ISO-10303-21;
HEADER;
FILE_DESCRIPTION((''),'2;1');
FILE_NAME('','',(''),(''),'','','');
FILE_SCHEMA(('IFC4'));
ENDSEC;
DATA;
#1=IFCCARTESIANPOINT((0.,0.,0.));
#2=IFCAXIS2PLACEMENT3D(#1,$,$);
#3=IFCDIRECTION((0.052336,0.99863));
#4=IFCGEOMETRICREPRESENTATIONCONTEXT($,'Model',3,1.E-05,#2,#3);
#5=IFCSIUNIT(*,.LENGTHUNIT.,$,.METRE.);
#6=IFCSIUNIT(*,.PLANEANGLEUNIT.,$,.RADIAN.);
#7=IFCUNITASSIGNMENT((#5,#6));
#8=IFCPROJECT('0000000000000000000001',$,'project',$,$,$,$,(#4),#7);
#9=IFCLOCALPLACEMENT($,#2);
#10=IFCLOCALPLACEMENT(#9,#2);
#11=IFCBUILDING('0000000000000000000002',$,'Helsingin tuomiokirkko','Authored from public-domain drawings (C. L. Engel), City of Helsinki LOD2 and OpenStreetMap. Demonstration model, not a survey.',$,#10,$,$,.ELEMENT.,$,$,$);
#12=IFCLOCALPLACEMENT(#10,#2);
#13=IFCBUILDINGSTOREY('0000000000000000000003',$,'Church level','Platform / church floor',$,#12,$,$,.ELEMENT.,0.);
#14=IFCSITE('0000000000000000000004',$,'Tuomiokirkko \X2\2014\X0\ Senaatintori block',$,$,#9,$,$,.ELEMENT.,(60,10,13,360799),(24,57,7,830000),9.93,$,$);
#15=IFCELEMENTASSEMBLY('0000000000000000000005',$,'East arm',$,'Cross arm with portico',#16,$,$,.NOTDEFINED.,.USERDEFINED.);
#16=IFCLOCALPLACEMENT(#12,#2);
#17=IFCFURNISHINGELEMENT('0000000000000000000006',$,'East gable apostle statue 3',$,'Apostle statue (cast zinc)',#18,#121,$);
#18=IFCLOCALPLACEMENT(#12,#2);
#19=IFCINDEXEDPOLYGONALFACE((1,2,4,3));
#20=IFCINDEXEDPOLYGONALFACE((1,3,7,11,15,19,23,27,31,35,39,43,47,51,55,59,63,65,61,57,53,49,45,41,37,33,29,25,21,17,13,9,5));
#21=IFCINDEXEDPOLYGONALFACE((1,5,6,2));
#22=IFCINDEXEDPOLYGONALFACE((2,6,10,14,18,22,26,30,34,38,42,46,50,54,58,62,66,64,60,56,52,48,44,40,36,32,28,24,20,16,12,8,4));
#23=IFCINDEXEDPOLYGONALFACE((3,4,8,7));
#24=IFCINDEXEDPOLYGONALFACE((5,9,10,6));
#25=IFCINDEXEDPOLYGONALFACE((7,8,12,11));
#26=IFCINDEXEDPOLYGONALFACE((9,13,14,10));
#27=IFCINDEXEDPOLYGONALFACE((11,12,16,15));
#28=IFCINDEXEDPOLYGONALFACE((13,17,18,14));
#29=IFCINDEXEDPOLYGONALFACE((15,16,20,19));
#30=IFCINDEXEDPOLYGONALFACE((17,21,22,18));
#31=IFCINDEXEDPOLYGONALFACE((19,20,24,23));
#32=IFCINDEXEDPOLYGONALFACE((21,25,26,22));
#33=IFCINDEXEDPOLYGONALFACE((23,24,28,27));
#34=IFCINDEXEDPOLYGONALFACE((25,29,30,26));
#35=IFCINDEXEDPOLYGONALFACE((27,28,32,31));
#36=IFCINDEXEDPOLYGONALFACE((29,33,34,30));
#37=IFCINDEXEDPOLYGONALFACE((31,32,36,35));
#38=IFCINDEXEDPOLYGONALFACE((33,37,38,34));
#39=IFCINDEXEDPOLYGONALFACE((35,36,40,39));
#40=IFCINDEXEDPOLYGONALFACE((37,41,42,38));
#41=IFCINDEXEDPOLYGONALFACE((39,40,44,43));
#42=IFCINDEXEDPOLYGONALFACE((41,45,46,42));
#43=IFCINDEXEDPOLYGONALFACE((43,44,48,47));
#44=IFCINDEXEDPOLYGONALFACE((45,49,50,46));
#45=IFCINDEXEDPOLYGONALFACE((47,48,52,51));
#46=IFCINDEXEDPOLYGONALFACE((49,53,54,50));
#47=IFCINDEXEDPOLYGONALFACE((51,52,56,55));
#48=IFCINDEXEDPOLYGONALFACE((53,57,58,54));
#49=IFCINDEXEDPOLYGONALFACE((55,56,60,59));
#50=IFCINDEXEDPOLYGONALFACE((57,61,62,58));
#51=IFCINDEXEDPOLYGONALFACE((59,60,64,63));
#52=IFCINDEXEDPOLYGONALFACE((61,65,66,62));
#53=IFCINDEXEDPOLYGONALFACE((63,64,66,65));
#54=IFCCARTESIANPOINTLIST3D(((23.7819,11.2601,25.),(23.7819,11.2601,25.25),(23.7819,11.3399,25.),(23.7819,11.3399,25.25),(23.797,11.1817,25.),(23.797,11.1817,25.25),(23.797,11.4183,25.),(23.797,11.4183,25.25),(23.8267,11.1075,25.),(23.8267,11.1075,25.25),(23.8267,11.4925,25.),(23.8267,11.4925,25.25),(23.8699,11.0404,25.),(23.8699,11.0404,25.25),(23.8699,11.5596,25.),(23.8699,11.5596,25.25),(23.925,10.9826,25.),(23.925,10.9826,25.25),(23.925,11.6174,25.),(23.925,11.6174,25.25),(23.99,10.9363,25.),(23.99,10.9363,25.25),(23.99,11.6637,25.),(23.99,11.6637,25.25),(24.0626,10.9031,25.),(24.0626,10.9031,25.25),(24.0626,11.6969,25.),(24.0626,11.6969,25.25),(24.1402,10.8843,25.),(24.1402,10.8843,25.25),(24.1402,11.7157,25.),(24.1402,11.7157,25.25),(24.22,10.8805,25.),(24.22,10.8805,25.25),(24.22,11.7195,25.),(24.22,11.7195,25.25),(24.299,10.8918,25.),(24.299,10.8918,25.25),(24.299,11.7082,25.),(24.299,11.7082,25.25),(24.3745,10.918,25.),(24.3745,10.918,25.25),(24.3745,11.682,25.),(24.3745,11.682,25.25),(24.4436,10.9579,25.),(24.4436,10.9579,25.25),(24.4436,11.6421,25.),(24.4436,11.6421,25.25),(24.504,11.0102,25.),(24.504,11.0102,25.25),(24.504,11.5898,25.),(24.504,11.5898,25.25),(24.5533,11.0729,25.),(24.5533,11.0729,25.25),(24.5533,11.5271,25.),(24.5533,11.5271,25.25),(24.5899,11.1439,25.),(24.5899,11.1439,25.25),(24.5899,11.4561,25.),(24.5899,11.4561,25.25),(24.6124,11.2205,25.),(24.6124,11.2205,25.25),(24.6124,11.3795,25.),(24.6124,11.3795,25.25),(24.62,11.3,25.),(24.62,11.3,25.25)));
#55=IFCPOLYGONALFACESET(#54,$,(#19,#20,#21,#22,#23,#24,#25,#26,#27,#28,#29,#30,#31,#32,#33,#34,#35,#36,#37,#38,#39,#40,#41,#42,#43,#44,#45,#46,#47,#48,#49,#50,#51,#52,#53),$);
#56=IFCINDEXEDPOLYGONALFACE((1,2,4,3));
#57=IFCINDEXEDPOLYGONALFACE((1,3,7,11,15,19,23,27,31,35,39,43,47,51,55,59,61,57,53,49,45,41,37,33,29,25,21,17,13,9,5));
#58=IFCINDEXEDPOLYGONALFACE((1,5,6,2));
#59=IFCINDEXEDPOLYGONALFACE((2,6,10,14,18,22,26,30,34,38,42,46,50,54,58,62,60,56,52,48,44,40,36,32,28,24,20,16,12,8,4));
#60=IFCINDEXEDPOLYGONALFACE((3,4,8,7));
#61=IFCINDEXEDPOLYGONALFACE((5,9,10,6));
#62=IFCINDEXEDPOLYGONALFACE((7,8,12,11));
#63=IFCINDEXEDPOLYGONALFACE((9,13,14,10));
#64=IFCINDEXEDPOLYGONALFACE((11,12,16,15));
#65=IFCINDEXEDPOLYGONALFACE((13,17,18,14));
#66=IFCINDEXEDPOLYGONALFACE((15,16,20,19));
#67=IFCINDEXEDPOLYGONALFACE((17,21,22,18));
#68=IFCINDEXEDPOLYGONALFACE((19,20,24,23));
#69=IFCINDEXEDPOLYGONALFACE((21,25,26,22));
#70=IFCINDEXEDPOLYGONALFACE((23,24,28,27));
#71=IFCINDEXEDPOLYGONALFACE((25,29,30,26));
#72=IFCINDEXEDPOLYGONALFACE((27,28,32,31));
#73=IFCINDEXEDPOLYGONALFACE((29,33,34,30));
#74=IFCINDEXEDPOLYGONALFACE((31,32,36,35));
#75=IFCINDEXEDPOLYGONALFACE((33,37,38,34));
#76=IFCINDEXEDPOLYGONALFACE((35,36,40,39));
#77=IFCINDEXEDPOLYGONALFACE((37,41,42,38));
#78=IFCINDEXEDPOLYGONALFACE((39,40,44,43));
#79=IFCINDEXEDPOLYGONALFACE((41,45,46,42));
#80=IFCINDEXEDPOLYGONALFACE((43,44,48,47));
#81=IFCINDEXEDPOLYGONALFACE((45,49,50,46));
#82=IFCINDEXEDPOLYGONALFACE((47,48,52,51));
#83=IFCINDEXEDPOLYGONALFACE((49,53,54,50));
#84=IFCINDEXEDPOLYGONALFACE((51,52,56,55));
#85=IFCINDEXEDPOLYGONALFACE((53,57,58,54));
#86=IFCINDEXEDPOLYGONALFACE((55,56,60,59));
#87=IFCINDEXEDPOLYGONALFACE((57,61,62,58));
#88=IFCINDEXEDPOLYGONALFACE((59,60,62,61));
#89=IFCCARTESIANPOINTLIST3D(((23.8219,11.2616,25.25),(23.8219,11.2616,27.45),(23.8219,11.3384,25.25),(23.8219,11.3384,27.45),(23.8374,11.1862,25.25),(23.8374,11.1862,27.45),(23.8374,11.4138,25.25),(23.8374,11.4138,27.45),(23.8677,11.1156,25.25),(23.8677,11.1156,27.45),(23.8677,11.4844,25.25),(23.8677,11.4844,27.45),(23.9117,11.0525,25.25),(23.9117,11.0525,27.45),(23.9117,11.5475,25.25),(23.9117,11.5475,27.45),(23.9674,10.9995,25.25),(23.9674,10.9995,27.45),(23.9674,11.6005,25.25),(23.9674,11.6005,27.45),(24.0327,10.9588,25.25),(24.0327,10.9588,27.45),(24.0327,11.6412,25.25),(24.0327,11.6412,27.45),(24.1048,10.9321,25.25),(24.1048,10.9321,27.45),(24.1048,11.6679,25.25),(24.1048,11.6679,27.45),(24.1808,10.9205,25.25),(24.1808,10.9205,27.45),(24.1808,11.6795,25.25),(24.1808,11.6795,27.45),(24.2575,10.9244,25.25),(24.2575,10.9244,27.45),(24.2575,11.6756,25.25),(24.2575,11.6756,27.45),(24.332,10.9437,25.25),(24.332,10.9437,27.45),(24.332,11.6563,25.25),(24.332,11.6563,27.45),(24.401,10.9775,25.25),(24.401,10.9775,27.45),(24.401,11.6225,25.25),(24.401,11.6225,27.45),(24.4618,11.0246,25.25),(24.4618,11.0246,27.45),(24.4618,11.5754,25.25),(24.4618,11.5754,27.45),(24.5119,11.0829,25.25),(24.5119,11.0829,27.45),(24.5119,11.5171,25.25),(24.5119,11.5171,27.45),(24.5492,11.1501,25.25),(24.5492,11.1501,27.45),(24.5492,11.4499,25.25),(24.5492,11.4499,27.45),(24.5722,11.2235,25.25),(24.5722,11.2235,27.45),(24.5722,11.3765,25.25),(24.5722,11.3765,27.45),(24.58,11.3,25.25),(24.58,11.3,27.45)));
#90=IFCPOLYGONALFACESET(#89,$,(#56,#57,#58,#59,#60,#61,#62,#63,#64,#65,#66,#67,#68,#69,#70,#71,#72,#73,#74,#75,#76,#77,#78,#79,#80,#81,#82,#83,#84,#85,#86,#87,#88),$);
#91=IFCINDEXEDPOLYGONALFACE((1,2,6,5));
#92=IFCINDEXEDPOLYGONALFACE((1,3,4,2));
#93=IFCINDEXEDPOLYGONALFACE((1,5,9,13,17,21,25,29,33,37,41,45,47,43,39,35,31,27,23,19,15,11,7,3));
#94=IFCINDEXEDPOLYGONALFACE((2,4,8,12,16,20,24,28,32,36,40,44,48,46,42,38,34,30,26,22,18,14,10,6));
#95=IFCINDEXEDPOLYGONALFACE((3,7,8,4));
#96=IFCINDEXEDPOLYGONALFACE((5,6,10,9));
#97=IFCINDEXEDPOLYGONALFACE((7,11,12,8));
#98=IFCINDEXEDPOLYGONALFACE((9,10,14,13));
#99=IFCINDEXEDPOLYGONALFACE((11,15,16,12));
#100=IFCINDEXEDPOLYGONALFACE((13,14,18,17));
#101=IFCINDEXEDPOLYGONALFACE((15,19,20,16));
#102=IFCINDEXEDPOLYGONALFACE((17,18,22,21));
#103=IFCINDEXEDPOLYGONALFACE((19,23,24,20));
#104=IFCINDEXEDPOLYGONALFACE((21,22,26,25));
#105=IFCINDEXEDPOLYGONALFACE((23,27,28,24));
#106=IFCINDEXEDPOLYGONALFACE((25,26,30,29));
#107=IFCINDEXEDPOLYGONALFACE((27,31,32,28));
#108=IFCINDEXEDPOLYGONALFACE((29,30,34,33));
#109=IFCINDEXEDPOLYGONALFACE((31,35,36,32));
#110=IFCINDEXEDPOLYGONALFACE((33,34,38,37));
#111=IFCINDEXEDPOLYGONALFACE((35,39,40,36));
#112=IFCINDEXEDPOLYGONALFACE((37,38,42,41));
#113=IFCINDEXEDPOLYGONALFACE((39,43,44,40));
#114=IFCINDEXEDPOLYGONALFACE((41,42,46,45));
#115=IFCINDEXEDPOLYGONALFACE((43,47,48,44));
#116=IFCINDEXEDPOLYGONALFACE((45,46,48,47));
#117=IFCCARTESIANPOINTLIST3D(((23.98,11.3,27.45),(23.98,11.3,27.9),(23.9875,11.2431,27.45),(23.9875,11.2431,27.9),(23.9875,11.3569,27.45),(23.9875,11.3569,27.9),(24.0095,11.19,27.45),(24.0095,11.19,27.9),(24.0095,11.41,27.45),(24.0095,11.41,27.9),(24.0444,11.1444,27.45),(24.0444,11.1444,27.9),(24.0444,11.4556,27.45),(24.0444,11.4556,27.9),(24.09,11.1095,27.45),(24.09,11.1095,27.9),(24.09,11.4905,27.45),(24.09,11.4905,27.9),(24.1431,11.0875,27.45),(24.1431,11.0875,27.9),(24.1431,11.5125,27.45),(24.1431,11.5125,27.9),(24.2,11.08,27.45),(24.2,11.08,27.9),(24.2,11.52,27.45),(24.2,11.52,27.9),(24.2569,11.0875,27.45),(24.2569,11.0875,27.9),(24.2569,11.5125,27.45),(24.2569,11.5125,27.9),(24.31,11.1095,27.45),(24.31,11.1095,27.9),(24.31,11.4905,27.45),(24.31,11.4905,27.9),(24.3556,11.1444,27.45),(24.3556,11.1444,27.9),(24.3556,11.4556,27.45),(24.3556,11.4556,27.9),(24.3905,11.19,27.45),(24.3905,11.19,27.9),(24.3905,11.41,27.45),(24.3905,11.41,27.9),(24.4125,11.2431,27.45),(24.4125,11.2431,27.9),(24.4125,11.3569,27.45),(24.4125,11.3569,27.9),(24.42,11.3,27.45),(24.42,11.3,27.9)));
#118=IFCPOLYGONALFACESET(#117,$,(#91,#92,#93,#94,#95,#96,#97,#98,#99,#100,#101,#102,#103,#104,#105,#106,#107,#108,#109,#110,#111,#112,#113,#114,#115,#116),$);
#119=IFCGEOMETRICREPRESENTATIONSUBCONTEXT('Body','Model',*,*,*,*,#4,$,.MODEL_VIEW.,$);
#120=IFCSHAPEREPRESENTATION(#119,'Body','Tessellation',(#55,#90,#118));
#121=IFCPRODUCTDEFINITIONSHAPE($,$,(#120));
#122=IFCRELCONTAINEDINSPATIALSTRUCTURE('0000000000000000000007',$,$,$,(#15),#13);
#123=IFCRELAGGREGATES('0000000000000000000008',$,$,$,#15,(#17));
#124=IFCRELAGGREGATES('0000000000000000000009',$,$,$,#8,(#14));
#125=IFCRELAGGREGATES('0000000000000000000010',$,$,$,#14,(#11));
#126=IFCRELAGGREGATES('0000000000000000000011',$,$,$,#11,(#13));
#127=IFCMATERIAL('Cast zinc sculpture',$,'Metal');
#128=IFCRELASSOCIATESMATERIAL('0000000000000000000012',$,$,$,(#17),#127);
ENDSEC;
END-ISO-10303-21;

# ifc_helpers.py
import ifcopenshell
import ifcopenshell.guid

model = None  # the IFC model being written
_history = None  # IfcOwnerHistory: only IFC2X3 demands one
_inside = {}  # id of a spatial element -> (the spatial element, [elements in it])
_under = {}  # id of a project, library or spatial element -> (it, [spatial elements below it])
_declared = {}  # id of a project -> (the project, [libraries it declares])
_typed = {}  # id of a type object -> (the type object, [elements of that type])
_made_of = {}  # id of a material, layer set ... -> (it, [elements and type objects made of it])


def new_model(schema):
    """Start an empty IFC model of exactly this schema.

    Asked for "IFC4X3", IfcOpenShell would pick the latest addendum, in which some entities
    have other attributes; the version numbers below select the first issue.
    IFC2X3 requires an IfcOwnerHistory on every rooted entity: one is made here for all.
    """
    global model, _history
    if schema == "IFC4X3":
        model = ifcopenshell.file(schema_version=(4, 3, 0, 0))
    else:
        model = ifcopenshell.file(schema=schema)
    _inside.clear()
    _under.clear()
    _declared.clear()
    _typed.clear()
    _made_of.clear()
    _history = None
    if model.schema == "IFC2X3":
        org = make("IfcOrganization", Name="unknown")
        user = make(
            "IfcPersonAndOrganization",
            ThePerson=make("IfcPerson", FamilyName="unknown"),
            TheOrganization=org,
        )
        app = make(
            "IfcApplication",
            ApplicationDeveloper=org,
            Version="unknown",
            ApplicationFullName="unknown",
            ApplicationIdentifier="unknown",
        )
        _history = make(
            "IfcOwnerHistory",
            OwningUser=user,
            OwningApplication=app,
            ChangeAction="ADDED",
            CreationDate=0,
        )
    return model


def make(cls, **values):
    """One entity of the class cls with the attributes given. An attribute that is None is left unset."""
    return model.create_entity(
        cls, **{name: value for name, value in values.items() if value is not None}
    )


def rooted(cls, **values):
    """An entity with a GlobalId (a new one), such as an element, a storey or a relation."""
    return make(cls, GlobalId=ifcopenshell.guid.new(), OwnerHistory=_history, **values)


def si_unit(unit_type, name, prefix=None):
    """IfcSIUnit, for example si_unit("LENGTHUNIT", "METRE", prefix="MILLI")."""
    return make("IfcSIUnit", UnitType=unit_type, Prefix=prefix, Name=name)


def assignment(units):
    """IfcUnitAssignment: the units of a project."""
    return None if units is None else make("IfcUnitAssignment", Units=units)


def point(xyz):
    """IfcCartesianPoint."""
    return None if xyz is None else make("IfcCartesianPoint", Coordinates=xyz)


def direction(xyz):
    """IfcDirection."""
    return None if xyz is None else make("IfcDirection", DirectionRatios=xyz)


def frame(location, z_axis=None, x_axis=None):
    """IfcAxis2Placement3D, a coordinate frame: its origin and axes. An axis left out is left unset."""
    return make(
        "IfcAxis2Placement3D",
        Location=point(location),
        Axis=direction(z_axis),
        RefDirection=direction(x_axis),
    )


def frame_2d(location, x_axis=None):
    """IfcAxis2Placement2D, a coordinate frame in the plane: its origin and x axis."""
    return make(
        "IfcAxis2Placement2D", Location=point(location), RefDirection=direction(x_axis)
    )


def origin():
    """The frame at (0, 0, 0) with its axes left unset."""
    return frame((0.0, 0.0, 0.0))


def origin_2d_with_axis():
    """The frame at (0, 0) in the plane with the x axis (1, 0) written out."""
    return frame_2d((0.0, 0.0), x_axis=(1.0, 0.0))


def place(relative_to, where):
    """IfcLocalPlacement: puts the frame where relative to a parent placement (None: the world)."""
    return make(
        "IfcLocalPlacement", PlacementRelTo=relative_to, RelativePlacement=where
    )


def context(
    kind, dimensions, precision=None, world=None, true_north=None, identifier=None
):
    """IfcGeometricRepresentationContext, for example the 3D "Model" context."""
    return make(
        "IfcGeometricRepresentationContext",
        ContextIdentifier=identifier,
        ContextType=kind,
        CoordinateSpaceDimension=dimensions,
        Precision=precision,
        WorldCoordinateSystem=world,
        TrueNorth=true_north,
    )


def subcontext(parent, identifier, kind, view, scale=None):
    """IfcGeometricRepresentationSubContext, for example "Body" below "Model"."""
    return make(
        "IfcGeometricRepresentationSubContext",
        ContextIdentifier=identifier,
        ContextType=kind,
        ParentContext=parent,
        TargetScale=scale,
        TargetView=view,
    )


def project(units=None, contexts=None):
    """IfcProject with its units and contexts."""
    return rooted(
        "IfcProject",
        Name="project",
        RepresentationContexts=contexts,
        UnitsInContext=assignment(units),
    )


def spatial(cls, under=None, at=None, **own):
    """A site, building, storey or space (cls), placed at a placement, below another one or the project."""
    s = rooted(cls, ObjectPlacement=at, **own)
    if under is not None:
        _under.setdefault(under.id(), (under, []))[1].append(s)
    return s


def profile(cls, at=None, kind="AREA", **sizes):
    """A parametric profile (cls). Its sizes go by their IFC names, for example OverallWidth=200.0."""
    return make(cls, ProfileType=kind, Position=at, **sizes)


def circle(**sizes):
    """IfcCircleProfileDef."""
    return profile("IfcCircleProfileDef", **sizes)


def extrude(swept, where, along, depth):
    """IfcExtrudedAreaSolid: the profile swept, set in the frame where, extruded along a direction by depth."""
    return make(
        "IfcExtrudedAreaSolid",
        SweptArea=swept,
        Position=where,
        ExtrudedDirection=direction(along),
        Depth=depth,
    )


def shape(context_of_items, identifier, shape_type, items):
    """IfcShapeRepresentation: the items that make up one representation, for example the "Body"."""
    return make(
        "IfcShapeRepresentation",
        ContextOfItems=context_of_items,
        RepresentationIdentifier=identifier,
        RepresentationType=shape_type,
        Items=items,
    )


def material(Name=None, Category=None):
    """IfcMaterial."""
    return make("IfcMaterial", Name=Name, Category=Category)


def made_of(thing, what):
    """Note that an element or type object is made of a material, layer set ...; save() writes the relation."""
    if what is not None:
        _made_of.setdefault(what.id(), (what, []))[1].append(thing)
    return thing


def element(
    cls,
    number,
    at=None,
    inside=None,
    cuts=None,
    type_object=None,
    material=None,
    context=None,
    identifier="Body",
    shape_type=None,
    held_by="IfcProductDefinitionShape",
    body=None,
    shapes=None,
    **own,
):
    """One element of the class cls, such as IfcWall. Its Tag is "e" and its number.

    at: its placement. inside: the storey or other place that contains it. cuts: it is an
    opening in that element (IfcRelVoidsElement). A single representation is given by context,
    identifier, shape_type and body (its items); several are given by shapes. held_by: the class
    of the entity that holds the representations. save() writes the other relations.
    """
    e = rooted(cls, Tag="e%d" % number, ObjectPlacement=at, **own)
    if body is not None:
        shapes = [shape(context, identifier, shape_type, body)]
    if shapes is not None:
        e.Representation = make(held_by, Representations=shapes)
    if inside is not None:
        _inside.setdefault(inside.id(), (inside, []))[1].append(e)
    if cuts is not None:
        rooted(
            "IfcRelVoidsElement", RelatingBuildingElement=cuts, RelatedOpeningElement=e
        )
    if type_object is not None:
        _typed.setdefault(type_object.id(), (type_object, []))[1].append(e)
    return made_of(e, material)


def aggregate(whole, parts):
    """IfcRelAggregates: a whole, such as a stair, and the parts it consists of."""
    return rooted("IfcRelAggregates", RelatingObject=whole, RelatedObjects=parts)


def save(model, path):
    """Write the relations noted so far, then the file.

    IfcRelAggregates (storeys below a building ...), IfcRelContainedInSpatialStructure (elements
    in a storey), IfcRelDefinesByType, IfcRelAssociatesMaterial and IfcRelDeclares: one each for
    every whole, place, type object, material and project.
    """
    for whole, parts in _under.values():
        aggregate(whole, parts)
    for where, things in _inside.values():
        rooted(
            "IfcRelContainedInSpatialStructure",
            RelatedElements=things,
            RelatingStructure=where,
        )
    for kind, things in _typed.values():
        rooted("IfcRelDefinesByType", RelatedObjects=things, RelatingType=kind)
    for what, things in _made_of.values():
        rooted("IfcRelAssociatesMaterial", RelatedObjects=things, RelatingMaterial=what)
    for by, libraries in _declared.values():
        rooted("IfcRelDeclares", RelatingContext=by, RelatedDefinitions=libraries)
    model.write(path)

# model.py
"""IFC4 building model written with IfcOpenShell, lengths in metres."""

from ifc_helpers import new_model, si_unit, direction, frame, origin, origin_2d_with_axis, place, context, subcontext, project, spatial, circle, extrude, material, element, aggregate, save


model = new_model("IFC4")

# Units and contexts
model_context = context("Model", 3, precision=1e-05, world=origin(), true_north=direction((0.052336, 0.99863)))
body_context = subcontext(model_context, "Body", "Model", "MODEL_VIEW")
ifc_project = project(units=[si_unit("LENGTHUNIT", "METRE"), si_unit("PLANEANGLEUNIT", "RADIAN")], contexts=[model_context])

# Site, building, storey
site_placement = place(None, origin())
site = spatial("IfcSite", under=ifc_project, at=site_placement, Name="Tuomiokirkko — Senaatintori block", CompositionType="ELEMENT", RefLatitude=(60, 10, 13, 360799), RefLongitude=(24, 57, 7, 830000), RefElevation=9.93)
building_placement = place(site_placement, origin())
building = spatial("IfcBuilding", under=site, at=building_placement, Name="Helsingin tuomiokirkko", Description="Authored from public-domain drawings (C. L. Engel), City of Helsinki LOD2 and OpenStreetMap. Demonstration model, not a survey.", CompositionType="ELEMENT")
storey_placement = place(building_placement, origin())
storey = spatial("IfcBuildingStorey", under=building, at=storey_placement, Name="Church level", Description="Platform / church floor", CompositionType="ELEMENT", Elevation=0.0)

# Element assembly
assembly_1_placement = place(building_placement, origin())
assembly_1 = element("IfcElementAssembly", 1, at=assembly_1_placement, inside=storey, Name="East arm", ObjectType="Cross arm with portico", AssemblyPlace="NOTDEFINED", PredefinedType="USERDEFINED")

# Furnishing element
ifc_material_1 = material(Name="Cast zinc sculpture", Category="Metal")
furnishing_1_placement = place(building_placement, origin())
furnishing_1 = element("IfcFurnishingElement", 2, at=furnishing_1_placement, material=ifc_material_1, Name="East gable apostle statue 3", ObjectType="Apostle statue (cast zinc)", context=body_context, shape_type="SweptSolid", body=[
    extrude(circle(Radius=0.42, at=origin_2d_with_axis()), frame((24.2, 11.3, 25.0)), (0.0, 0.0, 1.0), 0.25),
    extrude(circle(Radius=0.38, at=origin_2d_with_axis()), frame((24.2, 11.3, 25.25)), (0.0, 0.0, 1.0), 2.2),
    extrude(circle(Radius=0.22, at=origin_2d_with_axis()), frame((24.2, 11.3, 27.45)), (0.0, 0.0, 1.0), 0.45),
])
aggregate(assembly_1, [furnishing_1])

save(model, "model.ifc")
